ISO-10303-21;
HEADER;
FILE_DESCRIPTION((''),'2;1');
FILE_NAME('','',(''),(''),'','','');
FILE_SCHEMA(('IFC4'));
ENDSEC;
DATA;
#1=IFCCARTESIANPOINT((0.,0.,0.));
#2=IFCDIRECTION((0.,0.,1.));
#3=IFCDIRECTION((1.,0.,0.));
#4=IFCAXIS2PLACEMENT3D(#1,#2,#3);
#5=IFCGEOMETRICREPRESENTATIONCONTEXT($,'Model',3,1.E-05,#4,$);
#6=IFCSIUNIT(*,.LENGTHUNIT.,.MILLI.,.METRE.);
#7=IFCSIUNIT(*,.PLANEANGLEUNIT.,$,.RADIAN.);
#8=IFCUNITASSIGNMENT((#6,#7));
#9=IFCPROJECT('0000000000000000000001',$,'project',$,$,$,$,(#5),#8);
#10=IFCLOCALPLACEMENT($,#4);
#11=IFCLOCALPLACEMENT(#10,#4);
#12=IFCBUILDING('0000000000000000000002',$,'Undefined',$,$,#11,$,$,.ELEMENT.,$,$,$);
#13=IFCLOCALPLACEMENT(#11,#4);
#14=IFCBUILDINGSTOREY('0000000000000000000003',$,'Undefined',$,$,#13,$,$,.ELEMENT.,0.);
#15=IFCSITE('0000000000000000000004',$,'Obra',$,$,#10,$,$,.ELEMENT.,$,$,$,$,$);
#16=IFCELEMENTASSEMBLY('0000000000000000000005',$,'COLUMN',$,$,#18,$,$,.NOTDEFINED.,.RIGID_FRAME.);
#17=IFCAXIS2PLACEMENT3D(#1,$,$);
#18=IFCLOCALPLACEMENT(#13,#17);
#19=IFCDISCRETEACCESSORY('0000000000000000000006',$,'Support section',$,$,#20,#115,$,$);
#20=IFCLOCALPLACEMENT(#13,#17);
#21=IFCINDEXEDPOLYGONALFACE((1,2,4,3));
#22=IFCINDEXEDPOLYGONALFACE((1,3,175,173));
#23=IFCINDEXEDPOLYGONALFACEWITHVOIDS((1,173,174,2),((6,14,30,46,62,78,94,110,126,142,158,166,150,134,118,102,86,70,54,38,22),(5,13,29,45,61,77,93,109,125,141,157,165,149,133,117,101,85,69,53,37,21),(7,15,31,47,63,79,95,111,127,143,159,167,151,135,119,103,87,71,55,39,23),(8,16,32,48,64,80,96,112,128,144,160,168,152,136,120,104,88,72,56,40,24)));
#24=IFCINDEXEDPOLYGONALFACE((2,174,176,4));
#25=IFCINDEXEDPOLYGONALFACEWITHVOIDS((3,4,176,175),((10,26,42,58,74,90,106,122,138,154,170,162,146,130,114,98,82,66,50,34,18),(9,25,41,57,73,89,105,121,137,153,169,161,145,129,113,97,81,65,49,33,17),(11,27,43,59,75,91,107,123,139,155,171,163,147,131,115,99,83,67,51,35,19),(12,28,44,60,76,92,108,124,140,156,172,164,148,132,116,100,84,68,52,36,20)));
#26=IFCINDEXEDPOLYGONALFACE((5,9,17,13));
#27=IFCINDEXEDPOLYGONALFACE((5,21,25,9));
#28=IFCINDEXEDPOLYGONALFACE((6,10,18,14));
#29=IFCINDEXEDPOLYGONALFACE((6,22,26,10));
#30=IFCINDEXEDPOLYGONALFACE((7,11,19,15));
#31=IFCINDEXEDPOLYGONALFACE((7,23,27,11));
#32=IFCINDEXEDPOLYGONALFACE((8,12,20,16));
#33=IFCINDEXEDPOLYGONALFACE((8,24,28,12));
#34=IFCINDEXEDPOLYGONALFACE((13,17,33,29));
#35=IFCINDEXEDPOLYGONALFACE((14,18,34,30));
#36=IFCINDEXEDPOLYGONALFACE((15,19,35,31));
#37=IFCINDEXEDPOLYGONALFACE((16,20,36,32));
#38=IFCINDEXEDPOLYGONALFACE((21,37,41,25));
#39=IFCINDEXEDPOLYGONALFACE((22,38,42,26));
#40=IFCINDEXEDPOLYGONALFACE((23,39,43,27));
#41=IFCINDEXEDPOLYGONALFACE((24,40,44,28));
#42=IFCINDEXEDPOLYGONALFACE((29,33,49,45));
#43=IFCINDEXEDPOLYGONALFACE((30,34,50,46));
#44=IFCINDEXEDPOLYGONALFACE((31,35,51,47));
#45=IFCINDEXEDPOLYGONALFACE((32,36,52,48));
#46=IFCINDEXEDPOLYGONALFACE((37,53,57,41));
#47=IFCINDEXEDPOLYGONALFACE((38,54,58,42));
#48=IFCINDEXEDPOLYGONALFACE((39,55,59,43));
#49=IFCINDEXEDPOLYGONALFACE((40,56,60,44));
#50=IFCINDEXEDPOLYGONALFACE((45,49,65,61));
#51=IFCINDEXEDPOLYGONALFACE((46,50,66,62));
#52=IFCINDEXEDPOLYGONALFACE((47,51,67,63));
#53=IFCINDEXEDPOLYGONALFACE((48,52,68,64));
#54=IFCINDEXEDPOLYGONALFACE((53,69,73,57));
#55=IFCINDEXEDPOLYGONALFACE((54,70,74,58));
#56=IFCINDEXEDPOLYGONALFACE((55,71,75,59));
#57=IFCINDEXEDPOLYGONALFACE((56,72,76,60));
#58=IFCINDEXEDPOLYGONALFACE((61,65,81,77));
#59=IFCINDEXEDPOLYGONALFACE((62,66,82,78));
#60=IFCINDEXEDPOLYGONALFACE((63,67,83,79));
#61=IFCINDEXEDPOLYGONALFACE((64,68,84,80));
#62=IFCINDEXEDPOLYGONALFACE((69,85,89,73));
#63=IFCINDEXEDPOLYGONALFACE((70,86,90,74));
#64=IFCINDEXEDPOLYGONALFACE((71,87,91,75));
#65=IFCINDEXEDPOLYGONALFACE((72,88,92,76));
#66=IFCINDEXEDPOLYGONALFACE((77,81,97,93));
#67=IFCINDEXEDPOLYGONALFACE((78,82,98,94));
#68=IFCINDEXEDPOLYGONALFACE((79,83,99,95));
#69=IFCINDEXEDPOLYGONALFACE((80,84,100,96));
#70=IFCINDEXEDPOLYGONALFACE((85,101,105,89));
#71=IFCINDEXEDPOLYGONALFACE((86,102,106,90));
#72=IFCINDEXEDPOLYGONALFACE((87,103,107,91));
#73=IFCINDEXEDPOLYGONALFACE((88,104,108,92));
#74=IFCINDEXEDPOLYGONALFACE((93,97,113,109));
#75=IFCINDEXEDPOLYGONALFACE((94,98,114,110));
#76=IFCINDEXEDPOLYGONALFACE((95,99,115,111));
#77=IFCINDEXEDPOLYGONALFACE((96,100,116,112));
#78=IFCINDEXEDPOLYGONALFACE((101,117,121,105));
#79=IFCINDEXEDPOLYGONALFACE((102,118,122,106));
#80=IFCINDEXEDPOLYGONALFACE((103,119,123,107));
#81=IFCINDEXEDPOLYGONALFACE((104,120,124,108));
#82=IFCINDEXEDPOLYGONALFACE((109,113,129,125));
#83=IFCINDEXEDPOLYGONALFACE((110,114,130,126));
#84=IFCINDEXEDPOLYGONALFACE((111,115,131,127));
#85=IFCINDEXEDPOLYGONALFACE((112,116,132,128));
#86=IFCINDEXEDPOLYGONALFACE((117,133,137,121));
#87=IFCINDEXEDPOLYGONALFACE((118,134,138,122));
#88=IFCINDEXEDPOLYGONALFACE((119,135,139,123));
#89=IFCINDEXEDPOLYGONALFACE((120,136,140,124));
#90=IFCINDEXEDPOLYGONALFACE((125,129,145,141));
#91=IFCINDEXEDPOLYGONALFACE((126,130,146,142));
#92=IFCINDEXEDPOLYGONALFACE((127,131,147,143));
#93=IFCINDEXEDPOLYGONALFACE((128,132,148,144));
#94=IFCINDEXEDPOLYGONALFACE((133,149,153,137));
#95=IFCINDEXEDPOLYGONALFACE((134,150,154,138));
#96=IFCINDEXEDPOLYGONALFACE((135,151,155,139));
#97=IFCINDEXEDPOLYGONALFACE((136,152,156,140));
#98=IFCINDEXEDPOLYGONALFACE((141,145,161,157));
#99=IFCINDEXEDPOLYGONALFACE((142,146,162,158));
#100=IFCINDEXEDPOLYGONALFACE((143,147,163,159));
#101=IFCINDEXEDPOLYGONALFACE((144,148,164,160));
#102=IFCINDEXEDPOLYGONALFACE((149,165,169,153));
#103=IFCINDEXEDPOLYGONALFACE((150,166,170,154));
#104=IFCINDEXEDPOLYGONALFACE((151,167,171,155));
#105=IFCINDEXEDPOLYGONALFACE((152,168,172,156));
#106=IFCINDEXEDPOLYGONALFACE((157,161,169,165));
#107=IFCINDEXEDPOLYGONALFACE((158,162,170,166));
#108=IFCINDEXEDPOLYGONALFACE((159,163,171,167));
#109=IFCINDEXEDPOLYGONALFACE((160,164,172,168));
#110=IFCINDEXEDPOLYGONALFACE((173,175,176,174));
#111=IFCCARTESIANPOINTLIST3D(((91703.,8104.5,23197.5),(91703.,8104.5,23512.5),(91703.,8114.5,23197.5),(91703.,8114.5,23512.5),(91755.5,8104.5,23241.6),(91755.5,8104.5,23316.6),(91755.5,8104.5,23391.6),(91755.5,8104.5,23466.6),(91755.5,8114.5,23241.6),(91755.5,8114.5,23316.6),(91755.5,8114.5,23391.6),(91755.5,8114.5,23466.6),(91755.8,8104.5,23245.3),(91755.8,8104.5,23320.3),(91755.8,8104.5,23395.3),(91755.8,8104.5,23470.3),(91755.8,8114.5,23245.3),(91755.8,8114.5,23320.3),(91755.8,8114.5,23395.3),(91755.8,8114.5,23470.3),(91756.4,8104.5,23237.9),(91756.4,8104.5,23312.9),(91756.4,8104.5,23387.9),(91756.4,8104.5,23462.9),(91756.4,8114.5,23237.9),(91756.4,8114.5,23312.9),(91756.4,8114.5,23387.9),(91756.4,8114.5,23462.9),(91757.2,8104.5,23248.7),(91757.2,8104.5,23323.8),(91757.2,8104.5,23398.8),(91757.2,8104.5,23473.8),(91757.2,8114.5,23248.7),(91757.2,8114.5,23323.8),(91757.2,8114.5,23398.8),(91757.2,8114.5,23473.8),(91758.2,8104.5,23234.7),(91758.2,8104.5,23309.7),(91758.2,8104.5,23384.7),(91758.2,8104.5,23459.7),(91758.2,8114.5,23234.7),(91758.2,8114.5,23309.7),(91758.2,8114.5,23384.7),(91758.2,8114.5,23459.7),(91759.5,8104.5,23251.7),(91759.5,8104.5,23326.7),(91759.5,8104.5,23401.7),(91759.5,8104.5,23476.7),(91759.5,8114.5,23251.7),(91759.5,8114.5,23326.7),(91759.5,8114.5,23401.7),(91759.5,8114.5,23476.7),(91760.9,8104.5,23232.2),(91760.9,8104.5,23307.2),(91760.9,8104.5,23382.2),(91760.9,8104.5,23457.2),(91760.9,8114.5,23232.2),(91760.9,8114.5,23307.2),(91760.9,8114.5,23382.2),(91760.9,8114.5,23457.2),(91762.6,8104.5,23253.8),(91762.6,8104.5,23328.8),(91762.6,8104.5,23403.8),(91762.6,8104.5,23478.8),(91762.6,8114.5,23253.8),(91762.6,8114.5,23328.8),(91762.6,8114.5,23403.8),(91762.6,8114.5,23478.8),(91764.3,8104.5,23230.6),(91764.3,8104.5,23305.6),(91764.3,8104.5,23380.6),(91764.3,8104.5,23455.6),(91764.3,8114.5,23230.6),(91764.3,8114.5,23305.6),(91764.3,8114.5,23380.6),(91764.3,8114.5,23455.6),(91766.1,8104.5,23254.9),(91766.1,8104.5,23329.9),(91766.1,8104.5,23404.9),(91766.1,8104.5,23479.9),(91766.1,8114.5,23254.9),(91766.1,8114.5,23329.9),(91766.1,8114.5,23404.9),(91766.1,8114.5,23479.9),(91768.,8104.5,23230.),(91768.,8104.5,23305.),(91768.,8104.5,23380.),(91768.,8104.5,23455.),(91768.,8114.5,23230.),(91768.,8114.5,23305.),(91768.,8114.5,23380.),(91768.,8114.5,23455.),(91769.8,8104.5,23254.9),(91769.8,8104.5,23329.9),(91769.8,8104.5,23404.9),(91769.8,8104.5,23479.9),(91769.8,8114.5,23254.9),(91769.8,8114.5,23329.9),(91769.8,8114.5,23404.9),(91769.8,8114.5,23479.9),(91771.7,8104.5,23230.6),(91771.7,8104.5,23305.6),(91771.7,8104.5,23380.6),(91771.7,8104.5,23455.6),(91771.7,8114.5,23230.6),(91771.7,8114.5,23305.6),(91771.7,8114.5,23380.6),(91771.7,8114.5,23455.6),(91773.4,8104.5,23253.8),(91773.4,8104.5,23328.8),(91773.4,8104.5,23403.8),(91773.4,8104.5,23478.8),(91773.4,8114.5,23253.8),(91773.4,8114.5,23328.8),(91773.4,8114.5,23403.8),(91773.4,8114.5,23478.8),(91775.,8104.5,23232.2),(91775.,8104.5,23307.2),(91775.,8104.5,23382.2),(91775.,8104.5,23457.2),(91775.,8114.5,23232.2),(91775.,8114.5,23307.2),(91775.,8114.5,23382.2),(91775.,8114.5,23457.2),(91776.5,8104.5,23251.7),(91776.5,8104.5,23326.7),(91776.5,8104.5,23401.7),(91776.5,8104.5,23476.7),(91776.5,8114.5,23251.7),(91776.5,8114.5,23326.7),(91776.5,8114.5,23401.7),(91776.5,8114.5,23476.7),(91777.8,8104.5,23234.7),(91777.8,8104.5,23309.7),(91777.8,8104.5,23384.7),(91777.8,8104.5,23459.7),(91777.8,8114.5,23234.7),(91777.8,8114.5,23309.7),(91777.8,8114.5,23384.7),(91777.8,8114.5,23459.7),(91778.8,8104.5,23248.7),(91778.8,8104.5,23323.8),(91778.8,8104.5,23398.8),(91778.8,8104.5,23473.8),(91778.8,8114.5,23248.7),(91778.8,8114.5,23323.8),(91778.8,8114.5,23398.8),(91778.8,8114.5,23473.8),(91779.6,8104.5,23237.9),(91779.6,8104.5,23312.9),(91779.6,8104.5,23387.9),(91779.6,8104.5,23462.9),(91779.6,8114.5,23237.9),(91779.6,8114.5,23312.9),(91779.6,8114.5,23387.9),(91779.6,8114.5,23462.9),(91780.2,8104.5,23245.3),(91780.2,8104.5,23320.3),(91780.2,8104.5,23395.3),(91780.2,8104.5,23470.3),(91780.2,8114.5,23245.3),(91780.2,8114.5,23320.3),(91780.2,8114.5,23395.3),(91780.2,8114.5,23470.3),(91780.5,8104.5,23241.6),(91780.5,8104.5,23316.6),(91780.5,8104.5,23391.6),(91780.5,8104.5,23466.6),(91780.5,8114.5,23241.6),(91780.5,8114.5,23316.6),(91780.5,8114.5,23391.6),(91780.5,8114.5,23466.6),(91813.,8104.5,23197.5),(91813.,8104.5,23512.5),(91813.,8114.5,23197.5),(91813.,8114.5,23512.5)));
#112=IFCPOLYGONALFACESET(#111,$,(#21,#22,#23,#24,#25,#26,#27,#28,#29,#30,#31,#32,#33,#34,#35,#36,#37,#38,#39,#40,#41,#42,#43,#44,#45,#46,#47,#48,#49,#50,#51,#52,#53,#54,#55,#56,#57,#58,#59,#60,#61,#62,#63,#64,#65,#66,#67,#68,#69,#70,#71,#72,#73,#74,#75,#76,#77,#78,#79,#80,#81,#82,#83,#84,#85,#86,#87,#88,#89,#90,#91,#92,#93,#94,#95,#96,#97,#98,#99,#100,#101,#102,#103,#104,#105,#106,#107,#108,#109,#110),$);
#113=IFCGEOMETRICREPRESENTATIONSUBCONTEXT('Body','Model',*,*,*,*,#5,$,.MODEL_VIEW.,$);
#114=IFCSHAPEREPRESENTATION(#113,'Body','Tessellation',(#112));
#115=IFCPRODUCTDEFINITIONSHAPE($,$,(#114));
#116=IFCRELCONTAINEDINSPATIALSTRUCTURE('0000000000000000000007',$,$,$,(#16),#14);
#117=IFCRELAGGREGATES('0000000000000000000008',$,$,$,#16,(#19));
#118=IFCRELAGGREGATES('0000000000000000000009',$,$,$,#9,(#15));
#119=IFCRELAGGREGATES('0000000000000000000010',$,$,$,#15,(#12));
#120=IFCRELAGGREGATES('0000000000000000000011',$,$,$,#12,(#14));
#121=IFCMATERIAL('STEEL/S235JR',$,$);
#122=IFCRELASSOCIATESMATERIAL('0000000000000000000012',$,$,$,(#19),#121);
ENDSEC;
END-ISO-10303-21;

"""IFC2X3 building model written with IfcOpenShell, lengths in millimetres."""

from ifc_helpers import new_model, si_unit, frame, origin_with_axes, origin_2d_with_axis, place, context, subcontext, project, spatial, rectangle, circle, extrude, source, transform, mapped, material, element, aggregate, save


model = new_model("IFC2X3")

# Units and contexts
model_context = context("Model", 3, precision=1e-05, world=origin_with_axes())
body_context = subcontext(model_context, "Body", "Model", "MODEL_VIEW")
ifc_project = project(units=[si_unit("LENGTHUNIT", "METRE", prefix="MILLI"), si_unit("PLANEANGLEUNIT", "RADIAN")], contexts=[model_context])

# Site, building, storey
site_placement = place(None, origin_with_axes())
site = spatial("IfcSite", under=ifc_project, at=site_placement, Name="Obra", CompositionType="ELEMENT")
building_placement = place(site_placement, origin_with_axes())
building = spatial("IfcBuilding", under=site, at=building_placement, Name="Undefined", CompositionType="ELEMENT")
storey_placement = place(building_placement, origin_with_axes())
storey = spatial("IfcBuildingStorey", under=building, at=storey_placement, Name="Undefined", CompositionType="ELEMENT", Elevation=0.0)

# Shared definitions
ifc_material_1 = material(Name="STEEL/S235JR")

# Element assembly, discrete accessory, opening
assembly_1_placement = place(storey_placement, origin_with_axes())
assembly_1 = element("IfcElementAssembly", 1, at=assembly_1_placement, inside=storey, Name="COLUMN", AssemblyPlace="NOTDEFINED", PredefinedType="RIGID_FRAME")
discrete_accessory_1_placement = place(assembly_1_placement, frame((91758.0, 8109.5, 23197.5), z_axis=(0.0, 0.0, 1.0), x_axis=(-1.0, 0.0, 0.0)))
discrete_accessory_1 = element("IfcDiscreteAccessory", 2, at=discrete_accessory_1_placement, material=ifc_material_1, Name="Support section", context=body_context, shape_type="SweptSolid", body=[
    extrude(rectangle(XDim=10.0, YDim=110.0, at=origin_2d_with_axis()), frame((0.0, 0.0, 315.0), z_axis=(0.0, 0.0, -1.0), x_axis=(0.0, 1.0, 0.0)), (0.0, 0.0, 1.0), 315.0),
])
shared_shape_1 = source(origin_with_axes(), body_context, "Body", "SweptSolid", [
    extrude(circle(Radius=12.5, at=origin_2d_with_axis()), frame((0.0, -15.8, 0.0), z_axis=(0.0, 1.0, 0.0), x_axis=(1.0, 0.0, 0.0)), (0.0, 0.0, 1.0), 10.2),
])
opening_1_placement = place(assembly_1_placement, frame((91723.0, 8120.2, 23575.0), z_axis=(1.0, 0.0, 0.0), x_axis=(0.0, 0.0, -1.0)))
element("IfcOpeningElement", 3, at=opening_1_placement, cuts=discrete_accessory_1, ObjectType="Opening", context=body_context, shape_type="MappedRepresentation", body=[
    mapped(shared_shape_1, transform((107.5, 0.0, 45.0))),
    mapped(shared_shape_1, transform((182.5, 0.0, 45.0))),
    mapped(shared_shape_1, transform((257.5, 0.0, 45.0))),
    mapped(shared_shape_1, transform((332.5, 0.0, 45.0))),
])
aggregate(assembly_1, [discrete_accessory_1])

save(model, "model.ifc")
